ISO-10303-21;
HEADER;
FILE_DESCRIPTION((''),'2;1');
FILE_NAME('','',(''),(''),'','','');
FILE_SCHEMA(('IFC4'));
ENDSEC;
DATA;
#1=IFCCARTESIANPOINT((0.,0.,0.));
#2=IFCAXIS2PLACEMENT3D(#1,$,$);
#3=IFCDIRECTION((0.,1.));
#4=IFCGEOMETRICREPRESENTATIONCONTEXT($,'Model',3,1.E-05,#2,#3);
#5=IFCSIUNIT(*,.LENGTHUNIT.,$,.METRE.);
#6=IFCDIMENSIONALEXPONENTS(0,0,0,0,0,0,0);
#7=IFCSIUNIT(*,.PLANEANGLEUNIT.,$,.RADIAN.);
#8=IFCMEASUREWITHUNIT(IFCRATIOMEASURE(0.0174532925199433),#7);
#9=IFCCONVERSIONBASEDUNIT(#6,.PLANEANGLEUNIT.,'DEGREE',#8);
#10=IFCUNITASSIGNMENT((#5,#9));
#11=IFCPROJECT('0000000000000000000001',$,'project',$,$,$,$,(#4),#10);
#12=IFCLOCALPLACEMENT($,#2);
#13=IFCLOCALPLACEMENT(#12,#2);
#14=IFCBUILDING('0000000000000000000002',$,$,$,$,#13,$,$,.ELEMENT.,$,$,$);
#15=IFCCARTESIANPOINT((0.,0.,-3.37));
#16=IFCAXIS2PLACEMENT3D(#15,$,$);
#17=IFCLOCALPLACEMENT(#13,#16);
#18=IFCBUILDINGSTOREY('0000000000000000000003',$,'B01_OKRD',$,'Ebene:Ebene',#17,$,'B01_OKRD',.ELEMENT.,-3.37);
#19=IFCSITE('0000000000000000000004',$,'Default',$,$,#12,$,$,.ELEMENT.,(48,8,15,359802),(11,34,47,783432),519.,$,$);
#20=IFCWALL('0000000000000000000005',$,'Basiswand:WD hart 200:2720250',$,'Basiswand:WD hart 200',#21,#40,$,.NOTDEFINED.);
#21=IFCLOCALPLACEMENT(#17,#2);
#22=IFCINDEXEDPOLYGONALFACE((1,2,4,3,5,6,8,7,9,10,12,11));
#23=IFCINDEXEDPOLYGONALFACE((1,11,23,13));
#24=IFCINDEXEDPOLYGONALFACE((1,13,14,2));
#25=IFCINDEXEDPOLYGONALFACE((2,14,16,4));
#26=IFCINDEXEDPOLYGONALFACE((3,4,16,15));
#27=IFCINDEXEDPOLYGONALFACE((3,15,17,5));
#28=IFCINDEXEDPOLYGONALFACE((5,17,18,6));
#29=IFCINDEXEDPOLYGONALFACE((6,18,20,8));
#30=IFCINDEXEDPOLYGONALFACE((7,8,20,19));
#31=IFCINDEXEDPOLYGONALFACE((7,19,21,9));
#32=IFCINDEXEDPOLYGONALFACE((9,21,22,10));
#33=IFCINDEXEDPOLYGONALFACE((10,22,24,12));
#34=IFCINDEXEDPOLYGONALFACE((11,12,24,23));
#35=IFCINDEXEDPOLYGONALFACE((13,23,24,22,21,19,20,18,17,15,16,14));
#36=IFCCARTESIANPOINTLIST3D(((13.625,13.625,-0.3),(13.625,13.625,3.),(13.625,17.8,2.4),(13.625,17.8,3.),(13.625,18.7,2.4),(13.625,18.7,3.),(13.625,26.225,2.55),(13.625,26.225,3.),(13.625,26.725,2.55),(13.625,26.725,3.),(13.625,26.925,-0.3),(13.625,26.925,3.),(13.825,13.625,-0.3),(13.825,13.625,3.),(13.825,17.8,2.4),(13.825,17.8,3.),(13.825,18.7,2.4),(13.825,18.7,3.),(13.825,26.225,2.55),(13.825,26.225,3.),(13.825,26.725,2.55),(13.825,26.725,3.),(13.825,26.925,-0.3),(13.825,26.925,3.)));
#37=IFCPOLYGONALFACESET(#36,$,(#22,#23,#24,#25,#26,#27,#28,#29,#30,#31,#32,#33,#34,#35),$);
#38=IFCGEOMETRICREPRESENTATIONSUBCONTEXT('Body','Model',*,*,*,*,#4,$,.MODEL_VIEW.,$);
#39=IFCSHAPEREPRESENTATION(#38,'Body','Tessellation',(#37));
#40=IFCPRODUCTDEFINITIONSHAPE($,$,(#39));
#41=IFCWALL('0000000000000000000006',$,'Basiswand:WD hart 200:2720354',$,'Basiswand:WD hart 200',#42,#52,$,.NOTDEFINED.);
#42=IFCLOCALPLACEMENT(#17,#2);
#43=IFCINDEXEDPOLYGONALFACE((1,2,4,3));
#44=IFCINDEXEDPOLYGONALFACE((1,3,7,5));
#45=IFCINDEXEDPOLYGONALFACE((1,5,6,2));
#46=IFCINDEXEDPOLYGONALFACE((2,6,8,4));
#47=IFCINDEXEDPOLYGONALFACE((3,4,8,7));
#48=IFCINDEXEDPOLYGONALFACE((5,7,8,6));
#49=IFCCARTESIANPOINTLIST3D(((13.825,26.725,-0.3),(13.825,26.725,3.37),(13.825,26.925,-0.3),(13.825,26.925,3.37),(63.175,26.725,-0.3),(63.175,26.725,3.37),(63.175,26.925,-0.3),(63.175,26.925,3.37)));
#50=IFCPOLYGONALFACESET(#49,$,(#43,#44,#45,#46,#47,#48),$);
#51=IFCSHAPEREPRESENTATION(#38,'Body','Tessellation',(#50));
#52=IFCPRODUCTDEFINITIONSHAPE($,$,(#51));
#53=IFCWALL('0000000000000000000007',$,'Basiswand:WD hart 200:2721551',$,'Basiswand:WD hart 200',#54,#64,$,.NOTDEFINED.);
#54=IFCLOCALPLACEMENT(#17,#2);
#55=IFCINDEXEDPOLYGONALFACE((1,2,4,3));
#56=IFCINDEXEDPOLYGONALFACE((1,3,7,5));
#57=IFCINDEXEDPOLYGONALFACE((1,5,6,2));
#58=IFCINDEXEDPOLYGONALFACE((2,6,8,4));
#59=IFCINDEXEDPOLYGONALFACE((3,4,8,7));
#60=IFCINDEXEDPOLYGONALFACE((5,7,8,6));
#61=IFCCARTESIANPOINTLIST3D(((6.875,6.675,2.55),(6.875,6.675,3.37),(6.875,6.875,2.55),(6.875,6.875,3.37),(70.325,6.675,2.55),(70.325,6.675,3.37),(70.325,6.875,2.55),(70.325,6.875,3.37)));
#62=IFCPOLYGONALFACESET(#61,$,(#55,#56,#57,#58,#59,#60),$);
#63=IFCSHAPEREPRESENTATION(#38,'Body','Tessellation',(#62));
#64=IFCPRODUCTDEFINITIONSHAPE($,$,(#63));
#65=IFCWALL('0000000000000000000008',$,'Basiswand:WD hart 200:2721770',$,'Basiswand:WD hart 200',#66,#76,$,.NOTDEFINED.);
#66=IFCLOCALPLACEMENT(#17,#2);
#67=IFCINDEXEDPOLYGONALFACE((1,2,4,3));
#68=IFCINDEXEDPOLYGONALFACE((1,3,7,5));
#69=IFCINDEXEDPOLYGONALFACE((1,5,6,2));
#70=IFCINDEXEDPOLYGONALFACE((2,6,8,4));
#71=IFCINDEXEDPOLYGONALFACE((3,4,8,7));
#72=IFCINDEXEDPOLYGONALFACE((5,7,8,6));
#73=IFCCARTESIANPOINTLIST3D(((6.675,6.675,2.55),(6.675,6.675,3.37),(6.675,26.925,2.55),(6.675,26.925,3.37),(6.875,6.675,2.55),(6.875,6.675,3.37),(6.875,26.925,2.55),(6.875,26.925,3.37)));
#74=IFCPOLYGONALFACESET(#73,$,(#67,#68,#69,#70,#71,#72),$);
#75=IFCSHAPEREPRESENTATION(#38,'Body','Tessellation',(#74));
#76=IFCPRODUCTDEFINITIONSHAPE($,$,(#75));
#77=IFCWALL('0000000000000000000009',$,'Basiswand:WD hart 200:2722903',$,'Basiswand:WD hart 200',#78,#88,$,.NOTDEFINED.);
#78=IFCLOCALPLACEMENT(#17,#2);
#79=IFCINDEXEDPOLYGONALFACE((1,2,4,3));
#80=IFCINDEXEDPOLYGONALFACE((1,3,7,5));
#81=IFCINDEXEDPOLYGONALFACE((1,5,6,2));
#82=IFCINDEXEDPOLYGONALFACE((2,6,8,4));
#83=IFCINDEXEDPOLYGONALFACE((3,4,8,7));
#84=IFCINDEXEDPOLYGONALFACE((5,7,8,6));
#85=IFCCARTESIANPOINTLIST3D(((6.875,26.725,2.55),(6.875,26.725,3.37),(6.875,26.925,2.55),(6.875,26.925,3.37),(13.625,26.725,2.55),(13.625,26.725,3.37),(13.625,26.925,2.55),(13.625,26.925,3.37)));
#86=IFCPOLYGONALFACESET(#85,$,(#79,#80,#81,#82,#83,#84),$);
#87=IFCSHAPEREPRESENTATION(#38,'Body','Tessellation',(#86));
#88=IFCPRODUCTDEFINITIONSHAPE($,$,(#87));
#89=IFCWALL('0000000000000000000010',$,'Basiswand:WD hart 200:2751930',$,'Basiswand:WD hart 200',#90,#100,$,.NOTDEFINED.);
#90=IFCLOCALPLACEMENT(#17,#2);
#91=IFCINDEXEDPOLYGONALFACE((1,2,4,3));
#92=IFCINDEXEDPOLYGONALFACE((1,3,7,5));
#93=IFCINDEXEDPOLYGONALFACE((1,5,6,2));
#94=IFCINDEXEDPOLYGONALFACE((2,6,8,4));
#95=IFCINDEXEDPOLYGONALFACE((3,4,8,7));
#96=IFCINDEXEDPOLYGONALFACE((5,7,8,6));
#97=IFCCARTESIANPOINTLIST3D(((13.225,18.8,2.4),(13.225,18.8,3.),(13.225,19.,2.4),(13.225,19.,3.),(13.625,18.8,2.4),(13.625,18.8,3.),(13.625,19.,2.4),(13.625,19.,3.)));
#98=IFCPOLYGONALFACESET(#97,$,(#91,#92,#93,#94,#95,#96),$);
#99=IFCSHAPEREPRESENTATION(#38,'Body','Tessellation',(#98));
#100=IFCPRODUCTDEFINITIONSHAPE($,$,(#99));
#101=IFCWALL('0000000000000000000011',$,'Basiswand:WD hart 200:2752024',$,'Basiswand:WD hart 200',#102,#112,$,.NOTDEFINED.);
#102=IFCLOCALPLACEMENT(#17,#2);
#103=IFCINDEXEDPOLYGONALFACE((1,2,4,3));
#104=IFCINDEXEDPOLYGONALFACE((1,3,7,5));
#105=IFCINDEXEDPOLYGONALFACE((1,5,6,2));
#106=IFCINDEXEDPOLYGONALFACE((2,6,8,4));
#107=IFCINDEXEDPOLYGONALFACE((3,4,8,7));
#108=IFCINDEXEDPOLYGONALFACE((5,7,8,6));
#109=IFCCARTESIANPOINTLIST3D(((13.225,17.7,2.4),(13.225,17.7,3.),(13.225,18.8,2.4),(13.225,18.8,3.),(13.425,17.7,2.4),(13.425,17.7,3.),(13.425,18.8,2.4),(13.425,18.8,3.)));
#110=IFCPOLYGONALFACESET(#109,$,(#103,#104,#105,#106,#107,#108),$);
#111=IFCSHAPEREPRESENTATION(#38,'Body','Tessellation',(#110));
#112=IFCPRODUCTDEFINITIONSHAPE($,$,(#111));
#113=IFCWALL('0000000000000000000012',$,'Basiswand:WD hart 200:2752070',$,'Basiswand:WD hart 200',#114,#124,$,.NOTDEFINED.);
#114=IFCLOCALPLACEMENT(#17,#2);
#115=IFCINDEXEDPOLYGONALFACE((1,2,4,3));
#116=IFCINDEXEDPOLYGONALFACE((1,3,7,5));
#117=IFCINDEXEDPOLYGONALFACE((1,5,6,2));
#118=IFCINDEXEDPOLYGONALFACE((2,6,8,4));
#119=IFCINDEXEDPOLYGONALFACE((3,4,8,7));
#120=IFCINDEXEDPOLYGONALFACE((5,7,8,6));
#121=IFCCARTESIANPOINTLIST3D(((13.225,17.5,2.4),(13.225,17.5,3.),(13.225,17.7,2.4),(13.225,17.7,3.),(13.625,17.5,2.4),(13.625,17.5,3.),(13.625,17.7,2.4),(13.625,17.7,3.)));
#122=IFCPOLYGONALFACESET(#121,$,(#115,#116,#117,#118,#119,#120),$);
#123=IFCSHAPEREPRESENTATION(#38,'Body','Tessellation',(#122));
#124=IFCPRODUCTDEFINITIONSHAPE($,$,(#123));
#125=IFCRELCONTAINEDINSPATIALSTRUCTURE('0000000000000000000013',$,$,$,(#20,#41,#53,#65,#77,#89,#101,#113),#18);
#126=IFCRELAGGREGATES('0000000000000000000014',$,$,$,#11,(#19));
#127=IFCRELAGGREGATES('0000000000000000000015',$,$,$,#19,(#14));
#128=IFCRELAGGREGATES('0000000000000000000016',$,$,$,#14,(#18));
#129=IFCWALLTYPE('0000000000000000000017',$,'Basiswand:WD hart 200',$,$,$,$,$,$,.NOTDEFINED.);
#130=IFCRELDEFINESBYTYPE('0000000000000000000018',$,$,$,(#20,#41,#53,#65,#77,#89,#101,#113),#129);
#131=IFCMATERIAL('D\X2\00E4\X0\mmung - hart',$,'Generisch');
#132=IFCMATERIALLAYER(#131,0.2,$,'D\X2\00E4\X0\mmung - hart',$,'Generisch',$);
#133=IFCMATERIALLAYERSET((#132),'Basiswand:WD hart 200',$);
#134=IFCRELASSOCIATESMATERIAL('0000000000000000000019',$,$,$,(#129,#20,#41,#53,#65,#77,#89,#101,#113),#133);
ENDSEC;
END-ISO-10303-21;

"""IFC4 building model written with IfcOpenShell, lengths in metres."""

from ifc_helpers import new_model, entity, si_unit, converted_unit, direction, frame, frame_2d, origin, origin_2d_with_axis, place, context, subcontext, project, spatial, rectangle, extrude, material, layer, layer_set, layer_usage, type_object, element, save


model = new_model("IFC4")

# Units and contexts
model_context = context("Model", 3, precision=1e-05, world=origin(), true_north=direction((0.0, 1.0)))
body_context = subcontext(model_context, "Body", "Model", "MODEL_VIEW")
ifc_project = project(units=[si_unit("LENGTHUNIT", "METRE"), converted_unit("PLANEANGLEUNIT", "DEGREE", entity("IfcRatioMeasure", 0.0174532925199433), si_unit("PLANEANGLEUNIT", "RADIAN"), dimensions=[0, 0, 0, 0, 0, 0, 0])], contexts=[model_context])

# Site, building, storey
site_placement = place(None, frame((0.0, 0.0, 0.0)))
site = spatial("IfcSite", under=ifc_project, at=site_placement, Name="Default", CompositionType="ELEMENT", RefLatitude=(48, 8, 15, 359802), RefLongitude=(11, 34, 47, 783432), RefElevation=519.0)
building_placement = place(site_placement, origin())
building = spatial("IfcBuilding", under=site, at=building_placement, CompositionType="ELEMENT")
storey_placement = place(building_placement, frame((0.0, 0.0, -3.37)))
storey = spatial("IfcBuildingStorey", under=building, at=storey_placement, Name="B01_OKRD", ObjectType="Ebene:Ebene", LongName="B01_OKRD", CompositionType="ELEMENT", Elevation=-3.37)

# Shared definitions
ifc_material_1 = material(Name="Dämmung - hart", Category="Generisch")

# Wall, openings
ifc_layer_1 = layer(ifc_material_1, 0.2, Name="Dämmung - hart", Category="Generisch")
ifc_layer_set_1 = layer_set([ifc_layer_1], Name="Basiswand:WD hart 200")
ifc_layer_usage_1 = layer_usage(ifc_layer_set_1, "AXIS2", "POSITIVE", -0.1)
wall_type_1 = type_object("IfcWallType", Name="Basiswand:WD hart 200", PredefinedType="NOTDEFINED", material=ifc_layer_set_1)
wall_1_placement = place(storey_placement, frame((13.725, 13.625, -0.3), z_axis=(0.0, 0.0, 1.0), x_axis=(0.0, 1.0, 0.0)))
wall_1 = element("IfcWall", 1, at=wall_1_placement, inside=storey, type_object=wall_type_1, material=ifc_layer_usage_1, Name="Basiswand:WD hart 200:2720250", ObjectType="Basiswand:WD hart 200", PredefinedType="NOTDEFINED", context=body_context, shape_type="SweptSolid", body=[
    extrude(rectangle(XDim=13.3, YDim=0.2, at=frame_2d((6.65, 0.0), x_axis=(-1.0, 0.0))), origin(), (0.0, 0.0, 1.0), 3.3),
])
opening_1_placement = place(wall_1_placement, frame((4.175, 0.1, 2.7)))
element("IfcOpeningElement", 2, at=opening_1_placement, cuts=wall_1, ObjectType="Opening", PredefinedType="OPENING", context=body_context, shape_type="SweptSolid", body=[
    extrude(rectangle(XDim=0.6, YDim=0.9, at=origin_2d_with_axis()), frame((0.45, -0.2, 0.3), z_axis=(0.0, 1.0, 0.0), x_axis=(0.0, 0.0, -1.0)), (0.0, 0.0, 1.0), 0.2),
])
opening_2_placement = place(wall_1_placement, frame((12.6, 0.1, 2.85)))
element("IfcOpeningElement", 3, at=opening_2_placement, cuts=wall_1, ObjectType="Opening", PredefinedType="OPENING", context=body_context, shape_type="SweptSolid", body=[
    extrude(rectangle(XDim=0.45, YDim=0.5, at=origin_2d_with_axis()), frame((0.25, -0.2, 0.225), z_axis=(0.0, 1.0, 0.0), x_axis=(0.0, 0.0, -1.0)), (0.0, 0.0, 1.0), 0.2),
])

# Walls
ifc_layer_usage_2 = layer_usage(ifc_layer_set_1, "AXIS2", "POSITIVE", -0.1)
wall_2_placement = place(storey_placement, frame((13.725, 26.825, -0.3)))
element("IfcWall", 4, at=wall_2_placement, inside=storey, type_object=wall_type_1, material=ifc_layer_usage_2, Name="Basiswand:WD hart 200:2720354", ObjectType="Basiswand:WD hart 200", PredefinedType="NOTDEFINED", context=body_context, shape_type="SweptSolid", body=[
    extrude(rectangle(XDim=49.35, YDim=0.2, at=frame_2d((24.775, 0.0), x_axis=(-1.0, 0.0))), origin(), (0.0, 0.0, 1.0), 3.67),
])
ifc_layer_usage_3 = layer_usage(ifc_layer_set_1, "AXIS2", "NEGATIVE", 0.1)
wall_3_placement = place(storey_placement, frame((6.875, 6.775, 2.55)))
element("IfcWall", 5, at=wall_3_placement, inside=storey, type_object=wall_type_1, material=ifc_layer_usage_3, Name="Basiswand:WD hart 200:2721551", ObjectType="Basiswand:WD hart 200", PredefinedType="NOTDEFINED", context=body_context, shape_type="SweptSolid", body=[
    extrude(rectangle(XDim=63.45, YDim=0.2, at=frame_2d((31.725, 0.0), x_axis=(-1.0, 0.0))), origin(), (0.0, 0.0, 1.0), 0.82),
])
ifc_layer_usage_4 = layer_usage(ifc_layer_set_1, "AXIS2", "POSITIVE", -0.1)
wall_4_placement = place(storey_placement, frame((6.775, 6.675, 2.55), z_axis=(0.0, 0.0, 1.0), x_axis=(0.0, 1.0, 0.0)))
element("IfcWall", 6, at=wall_4_placement, inside=storey, type_object=wall_type_1, material=ifc_layer_usage_4, Name="Basiswand:WD hart 200:2721770", ObjectType="Basiswand:WD hart 200", PredefinedType="NOTDEFINED", context=body_context, shape_type="SweptSolid", body=[
    extrude(rectangle(XDim=20.25, YDim=0.2, at=frame_2d((10.125, 0.0), x_axis=(-1.0, 0.0))), origin(), (0.0, 0.0, 1.0), 0.82),
])
ifc_layer_usage_5 = layer_usage(ifc_layer_set_1, "AXIS2", "POSITIVE", -0.1)
wall_5_placement = place(storey_placement, frame((13.725, 26.825, 2.55), z_axis=(0.0, 0.0, 1.0), x_axis=(-1.0, 0.0, 0.0)))
element("IfcWall", 7, at=wall_5_placement, inside=storey, type_object=wall_type_1, material=ifc_layer_usage_5, Name="Basiswand:WD hart 200:2722903", ObjectType="Basiswand:WD hart 200", PredefinedType="NOTDEFINED", context=body_context, shape_type="SweptSolid", body=[
    extrude(rectangle(XDim=6.75, YDim=0.2, at=frame_2d((3.475, 0.0), x_axis=(-1.0, 0.0))), origin(), (0.0, 0.0, 1.0), 0.82),
])
ifc_layer_usage_6 = layer_usage(ifc_layer_set_1, "AXIS2", "NEGATIVE", 0.1)
wall_6_placement = place(storey_placement, frame((13.625, 18.9, 2.4), z_axis=(0.0, 0.0, 1.0), x_axis=(-1.0, 0.0, 0.0)))
element("IfcWall", 8, at=wall_6_placement, inside=storey, type_object=wall_type_1, material=ifc_layer_usage_6, Name="Basiswand:WD hart 200:2751930", ObjectType="Basiswand:WD hart 200", PredefinedType="NOTDEFINED", context=body_context, shape_type="SweptSolid", body=[
    extrude(rectangle(XDim=0.4, YDim=0.2, at=frame_2d((0.2, 0.0), x_axis=(-1.0, 0.0))), origin(), (0.0, 0.0, 1.0), 0.6),
])
ifc_layer_usage_7 = layer_usage(ifc_layer_set_1, "AXIS2", "NEGATIVE", 0.1)
wall_7_placement = place(storey_placement, frame((13.325, 18.8, 2.4), z_axis=(0.0, 0.0, 1.0), x_axis=(0.0, -1.0, 0.0)))
element("IfcWall", 9, at=wall_7_placement, inside=storey, type_object=wall_type_1, material=ifc_layer_usage_7, Name="Basiswand:WD hart 200:2752024", ObjectType="Basiswand:WD hart 200", PredefinedType="NOTDEFINED", context=body_context, shape_type="SweptSolid", body=[
    extrude(rectangle(XDim=1.1, YDim=0.2, at=frame_2d((0.55, 0.0), x_axis=(-1.0, 0.0))), origin(), (0.0, 0.0, 1.0), 0.6),
])
ifc_layer_usage_8 = layer_usage(ifc_layer_set_1, "AXIS2", "NEGATIVE", 0.1)
wall_8_placement = place(storey_placement, frame((13.225, 17.6, 2.4)))
element("IfcWall", 10, at=wall_8_placement, inside=storey, type_object=wall_type_1, material=ifc_layer_usage_8, Name="Basiswand:WD hart 200:2752070", ObjectType="Basiswand:WD hart 200", PredefinedType="NOTDEFINED", context=body_context, shape_type="SweptSolid", body=[
    extrude(rectangle(XDim=0.4, YDim=0.2, at=frame_2d((0.2, 0.0), x_axis=(-1.0, 0.0))), origin(), (0.0, 0.0, 1.0), 0.6),
])

save(model, "model.ifc")
